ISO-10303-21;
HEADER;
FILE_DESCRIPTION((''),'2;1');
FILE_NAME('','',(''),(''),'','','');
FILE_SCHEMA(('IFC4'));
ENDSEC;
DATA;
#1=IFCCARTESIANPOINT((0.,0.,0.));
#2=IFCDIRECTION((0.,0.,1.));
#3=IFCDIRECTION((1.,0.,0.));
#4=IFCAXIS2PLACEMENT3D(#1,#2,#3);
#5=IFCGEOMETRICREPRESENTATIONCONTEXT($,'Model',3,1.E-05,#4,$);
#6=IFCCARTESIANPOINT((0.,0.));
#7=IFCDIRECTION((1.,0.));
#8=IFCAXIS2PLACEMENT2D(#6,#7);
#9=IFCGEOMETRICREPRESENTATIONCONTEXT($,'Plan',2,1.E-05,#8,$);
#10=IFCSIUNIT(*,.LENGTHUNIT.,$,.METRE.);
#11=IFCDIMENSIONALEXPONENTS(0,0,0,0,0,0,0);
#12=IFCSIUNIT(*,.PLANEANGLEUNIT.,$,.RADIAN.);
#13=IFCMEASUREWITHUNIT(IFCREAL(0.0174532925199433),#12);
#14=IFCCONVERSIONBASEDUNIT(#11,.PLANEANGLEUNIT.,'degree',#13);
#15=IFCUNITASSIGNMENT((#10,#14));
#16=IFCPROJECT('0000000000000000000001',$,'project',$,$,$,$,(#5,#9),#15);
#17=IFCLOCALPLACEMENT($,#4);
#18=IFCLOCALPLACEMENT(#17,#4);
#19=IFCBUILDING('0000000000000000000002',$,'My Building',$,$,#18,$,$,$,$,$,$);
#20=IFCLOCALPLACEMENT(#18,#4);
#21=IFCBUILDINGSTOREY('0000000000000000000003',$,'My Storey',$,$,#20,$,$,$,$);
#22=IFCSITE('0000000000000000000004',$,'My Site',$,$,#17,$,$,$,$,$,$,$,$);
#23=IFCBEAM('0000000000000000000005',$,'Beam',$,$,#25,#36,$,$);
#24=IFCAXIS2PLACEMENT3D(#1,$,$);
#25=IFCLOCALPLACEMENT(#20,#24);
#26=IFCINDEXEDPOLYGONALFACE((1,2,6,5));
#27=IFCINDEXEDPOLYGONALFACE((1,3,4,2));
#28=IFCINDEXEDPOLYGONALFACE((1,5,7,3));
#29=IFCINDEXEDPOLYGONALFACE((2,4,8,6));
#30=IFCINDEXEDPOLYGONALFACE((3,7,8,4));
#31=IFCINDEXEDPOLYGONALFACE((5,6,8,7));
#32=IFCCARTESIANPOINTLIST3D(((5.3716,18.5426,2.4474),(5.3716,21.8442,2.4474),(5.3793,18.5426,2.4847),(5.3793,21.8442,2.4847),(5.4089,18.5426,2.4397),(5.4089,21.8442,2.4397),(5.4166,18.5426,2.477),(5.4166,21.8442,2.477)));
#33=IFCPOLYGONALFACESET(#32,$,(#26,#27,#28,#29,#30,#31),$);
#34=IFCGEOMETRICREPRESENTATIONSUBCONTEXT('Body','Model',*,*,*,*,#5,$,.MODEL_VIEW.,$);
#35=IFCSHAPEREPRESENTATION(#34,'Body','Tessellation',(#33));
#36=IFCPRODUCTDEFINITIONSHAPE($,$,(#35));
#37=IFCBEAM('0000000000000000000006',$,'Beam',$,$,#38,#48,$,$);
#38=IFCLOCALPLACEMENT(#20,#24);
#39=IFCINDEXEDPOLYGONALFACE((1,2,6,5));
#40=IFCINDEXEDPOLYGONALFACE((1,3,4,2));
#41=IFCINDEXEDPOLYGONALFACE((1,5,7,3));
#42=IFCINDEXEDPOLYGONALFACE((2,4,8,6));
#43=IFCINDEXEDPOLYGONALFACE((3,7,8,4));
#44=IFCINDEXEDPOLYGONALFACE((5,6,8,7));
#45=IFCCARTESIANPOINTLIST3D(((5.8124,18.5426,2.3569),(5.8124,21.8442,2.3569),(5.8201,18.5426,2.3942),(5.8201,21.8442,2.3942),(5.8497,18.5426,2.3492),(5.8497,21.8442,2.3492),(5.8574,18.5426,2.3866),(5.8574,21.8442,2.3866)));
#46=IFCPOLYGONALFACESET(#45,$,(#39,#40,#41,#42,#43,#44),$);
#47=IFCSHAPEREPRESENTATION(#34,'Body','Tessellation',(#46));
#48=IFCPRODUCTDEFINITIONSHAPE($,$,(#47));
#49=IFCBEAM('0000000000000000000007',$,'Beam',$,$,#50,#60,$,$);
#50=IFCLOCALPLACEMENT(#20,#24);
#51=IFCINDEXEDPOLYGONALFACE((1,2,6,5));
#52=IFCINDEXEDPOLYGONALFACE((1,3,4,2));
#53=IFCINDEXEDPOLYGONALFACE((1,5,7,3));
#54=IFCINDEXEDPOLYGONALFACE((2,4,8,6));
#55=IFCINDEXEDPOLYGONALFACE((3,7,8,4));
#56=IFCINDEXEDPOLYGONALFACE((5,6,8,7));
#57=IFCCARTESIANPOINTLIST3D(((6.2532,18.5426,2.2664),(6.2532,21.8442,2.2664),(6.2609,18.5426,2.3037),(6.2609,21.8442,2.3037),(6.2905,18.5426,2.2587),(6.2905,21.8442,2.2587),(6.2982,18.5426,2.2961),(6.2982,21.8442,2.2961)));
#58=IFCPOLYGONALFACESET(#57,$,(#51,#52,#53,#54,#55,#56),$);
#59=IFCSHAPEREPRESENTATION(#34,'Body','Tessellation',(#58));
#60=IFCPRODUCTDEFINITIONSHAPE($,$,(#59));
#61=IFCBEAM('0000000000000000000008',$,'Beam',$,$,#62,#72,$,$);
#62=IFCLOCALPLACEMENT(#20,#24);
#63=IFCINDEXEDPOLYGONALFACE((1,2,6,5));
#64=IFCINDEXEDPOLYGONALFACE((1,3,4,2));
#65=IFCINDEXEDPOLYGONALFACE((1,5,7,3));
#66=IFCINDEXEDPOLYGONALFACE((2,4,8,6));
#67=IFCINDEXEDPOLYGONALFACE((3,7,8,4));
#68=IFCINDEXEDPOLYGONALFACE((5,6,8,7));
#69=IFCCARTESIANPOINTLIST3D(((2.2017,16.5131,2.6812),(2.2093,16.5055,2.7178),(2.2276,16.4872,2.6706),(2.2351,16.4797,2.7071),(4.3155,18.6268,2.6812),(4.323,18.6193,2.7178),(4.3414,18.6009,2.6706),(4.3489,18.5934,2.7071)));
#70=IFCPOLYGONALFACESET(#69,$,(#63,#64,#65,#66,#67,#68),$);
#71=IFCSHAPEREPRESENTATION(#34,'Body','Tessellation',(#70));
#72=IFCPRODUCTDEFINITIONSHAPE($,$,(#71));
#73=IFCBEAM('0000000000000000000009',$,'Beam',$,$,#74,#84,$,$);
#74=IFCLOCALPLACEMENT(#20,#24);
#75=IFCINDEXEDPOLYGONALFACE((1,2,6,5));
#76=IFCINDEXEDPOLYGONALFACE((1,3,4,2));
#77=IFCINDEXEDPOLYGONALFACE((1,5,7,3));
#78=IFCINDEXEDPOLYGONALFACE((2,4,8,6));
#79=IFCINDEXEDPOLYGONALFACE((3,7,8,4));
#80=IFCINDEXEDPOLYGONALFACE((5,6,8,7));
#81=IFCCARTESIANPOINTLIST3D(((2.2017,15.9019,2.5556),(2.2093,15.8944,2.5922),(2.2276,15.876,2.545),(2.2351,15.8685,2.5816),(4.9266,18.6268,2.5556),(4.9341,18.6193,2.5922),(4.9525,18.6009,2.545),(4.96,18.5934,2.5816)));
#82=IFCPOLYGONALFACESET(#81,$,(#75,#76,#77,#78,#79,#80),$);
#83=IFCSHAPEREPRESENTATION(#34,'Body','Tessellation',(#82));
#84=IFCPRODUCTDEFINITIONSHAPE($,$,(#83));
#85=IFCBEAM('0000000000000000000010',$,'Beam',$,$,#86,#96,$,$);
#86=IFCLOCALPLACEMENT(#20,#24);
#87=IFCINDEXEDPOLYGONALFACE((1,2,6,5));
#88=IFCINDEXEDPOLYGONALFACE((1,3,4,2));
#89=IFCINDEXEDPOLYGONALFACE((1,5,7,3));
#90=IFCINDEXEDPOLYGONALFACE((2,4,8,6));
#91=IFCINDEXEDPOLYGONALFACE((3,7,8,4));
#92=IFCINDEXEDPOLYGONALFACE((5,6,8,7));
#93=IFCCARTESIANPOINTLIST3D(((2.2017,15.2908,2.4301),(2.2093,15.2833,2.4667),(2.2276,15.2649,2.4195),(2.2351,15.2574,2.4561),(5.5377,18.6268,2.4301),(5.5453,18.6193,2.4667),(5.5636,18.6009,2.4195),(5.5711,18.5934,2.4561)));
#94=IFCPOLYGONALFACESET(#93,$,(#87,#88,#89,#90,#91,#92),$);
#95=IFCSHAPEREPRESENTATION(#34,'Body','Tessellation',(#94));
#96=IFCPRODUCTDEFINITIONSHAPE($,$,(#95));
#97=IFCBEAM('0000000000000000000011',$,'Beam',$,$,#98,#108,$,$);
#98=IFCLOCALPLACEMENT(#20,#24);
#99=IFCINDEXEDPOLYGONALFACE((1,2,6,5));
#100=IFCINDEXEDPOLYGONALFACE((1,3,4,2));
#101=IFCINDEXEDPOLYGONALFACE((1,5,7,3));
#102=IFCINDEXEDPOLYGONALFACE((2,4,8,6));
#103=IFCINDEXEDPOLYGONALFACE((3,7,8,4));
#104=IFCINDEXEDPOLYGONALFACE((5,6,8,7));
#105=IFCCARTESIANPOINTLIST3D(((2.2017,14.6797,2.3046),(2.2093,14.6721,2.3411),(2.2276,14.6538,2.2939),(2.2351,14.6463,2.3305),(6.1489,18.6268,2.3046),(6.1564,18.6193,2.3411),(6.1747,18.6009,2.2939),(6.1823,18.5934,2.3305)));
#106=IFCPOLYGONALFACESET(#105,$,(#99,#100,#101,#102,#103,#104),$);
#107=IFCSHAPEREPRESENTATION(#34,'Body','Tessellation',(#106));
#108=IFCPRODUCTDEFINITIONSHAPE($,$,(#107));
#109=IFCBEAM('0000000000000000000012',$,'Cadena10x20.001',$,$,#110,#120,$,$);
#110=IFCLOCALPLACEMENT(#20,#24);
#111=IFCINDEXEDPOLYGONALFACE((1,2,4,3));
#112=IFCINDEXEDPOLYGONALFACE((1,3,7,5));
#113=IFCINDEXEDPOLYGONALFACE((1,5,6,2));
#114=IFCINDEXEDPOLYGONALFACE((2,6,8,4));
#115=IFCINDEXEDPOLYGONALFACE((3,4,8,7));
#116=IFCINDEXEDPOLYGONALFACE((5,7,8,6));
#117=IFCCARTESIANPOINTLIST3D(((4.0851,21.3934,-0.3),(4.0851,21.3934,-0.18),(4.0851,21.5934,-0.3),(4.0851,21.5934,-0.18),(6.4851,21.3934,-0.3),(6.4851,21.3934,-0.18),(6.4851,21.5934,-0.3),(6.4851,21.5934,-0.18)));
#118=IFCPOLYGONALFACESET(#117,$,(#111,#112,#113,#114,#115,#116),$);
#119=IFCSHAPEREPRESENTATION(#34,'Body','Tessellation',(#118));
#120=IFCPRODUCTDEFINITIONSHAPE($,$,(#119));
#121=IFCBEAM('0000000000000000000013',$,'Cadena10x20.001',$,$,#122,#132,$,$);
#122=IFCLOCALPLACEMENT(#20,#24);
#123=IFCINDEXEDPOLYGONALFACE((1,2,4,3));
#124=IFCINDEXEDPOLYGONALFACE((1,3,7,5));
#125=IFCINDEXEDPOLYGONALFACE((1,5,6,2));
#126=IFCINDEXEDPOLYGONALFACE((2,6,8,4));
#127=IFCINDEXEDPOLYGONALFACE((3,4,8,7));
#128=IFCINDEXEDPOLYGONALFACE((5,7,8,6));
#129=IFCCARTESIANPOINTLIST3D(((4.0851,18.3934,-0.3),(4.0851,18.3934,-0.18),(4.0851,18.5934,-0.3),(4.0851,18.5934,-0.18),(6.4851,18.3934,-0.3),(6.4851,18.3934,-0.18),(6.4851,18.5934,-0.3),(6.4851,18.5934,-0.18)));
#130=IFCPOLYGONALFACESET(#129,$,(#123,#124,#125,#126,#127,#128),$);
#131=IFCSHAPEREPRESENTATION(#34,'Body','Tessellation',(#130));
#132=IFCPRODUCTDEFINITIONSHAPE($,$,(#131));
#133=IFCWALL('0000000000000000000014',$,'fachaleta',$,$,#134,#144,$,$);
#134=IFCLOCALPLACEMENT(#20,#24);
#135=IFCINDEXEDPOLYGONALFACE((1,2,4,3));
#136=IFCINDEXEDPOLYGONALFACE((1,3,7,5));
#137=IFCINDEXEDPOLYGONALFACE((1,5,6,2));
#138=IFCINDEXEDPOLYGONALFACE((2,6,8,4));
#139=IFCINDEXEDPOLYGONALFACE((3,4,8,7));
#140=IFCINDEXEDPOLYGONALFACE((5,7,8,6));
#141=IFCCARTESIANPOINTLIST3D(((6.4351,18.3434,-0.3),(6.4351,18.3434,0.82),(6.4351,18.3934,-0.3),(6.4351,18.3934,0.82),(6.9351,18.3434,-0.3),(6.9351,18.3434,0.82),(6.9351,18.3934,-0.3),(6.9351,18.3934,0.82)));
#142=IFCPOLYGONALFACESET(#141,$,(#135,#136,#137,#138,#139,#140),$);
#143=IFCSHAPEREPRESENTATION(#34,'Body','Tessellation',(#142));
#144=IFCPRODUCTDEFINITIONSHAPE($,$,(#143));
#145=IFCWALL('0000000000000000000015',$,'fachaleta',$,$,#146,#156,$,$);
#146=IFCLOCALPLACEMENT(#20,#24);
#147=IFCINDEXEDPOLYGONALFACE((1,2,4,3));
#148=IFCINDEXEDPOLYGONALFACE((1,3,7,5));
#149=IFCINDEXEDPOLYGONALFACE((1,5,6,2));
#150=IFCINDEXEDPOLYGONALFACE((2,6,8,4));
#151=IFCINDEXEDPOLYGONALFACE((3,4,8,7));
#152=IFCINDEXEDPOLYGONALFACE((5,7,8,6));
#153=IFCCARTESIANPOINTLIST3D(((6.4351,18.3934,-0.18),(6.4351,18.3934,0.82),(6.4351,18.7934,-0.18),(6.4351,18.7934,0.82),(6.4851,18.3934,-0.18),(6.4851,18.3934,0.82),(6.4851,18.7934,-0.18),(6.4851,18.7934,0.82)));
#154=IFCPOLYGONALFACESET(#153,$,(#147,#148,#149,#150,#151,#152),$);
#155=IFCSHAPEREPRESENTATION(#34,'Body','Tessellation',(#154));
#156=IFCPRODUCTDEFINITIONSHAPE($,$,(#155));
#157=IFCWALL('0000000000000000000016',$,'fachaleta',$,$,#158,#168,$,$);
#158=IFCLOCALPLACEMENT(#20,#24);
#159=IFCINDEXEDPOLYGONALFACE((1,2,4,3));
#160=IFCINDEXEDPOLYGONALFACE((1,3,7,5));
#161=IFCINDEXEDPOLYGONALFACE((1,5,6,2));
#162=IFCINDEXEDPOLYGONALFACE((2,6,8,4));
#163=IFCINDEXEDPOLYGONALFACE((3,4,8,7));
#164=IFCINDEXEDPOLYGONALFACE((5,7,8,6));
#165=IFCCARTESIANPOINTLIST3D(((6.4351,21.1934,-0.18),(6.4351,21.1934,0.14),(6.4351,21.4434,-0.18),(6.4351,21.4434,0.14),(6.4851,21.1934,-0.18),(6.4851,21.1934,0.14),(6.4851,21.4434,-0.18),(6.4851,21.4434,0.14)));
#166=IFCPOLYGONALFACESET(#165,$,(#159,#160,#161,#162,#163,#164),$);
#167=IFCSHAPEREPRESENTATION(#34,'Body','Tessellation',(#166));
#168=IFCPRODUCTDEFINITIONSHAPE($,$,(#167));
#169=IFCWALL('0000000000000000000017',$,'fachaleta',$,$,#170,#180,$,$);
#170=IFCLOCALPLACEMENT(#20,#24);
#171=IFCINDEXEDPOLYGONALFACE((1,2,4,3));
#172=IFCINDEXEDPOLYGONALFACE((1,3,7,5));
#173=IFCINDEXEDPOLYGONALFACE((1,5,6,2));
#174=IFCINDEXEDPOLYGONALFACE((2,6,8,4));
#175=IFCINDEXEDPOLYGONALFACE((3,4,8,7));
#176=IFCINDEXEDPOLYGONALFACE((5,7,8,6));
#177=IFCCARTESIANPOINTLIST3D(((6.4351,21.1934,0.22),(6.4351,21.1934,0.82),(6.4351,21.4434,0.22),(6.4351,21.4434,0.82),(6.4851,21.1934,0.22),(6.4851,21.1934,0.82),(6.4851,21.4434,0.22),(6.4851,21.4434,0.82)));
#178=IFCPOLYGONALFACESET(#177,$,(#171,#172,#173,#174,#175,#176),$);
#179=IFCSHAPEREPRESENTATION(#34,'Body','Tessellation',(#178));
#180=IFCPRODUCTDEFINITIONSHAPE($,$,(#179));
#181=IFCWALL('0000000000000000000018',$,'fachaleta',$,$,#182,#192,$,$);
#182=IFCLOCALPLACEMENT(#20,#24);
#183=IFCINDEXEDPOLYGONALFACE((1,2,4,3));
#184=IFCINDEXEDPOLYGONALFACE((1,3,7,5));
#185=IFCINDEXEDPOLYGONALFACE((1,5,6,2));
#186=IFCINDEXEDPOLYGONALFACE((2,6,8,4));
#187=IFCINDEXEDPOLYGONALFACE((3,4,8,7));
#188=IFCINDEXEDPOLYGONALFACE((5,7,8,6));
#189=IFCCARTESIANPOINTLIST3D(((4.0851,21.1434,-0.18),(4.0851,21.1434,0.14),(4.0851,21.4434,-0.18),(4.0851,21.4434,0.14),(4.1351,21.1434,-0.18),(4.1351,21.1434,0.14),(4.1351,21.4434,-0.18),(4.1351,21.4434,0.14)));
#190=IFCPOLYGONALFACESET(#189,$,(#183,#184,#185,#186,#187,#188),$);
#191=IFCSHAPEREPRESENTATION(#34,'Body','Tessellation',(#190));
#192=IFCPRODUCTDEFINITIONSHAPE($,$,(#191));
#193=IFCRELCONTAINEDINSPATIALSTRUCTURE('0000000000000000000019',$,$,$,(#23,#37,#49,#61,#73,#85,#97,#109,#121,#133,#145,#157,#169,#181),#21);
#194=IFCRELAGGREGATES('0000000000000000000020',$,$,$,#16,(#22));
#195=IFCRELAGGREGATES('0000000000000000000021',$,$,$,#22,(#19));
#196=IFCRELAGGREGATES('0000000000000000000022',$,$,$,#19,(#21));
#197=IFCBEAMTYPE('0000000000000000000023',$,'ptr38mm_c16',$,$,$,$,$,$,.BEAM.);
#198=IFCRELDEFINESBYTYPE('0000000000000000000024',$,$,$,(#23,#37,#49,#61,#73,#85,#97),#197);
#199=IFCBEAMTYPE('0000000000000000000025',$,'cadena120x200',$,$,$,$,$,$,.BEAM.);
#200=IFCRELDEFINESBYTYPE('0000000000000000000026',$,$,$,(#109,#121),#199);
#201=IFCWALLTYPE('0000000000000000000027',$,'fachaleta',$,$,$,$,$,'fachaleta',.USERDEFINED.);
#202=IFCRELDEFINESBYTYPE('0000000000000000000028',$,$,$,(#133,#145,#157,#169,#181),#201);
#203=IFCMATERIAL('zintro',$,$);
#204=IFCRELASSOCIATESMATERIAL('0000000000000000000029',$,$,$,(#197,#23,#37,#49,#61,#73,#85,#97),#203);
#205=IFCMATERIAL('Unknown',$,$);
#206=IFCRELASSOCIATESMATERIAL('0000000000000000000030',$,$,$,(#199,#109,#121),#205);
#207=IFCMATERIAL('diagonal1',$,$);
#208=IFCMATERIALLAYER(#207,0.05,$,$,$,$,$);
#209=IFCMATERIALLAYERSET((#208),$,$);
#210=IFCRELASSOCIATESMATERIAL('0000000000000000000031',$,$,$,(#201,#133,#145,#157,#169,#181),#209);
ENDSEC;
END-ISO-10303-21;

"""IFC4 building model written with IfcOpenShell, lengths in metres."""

from ifc_helpers import new_model, entity, si_unit, converted_unit, frame, origin_with_axes, origin_2d_with_axis, place, context, subcontext, project, spatial, indexed_curve, rectangle, outline, extrude, material, layer, layer_set, layer_usage, material_profile, profile_set, profile_usage, type_object, element, save


model = new_model("IFC4")

# Units and contexts
model_context = context("Model", 3, precision=1e-05, world=origin_with_axes())
plan_context = context("Plan", 2, precision=1e-05, world=origin_2d_with_axis())
body_context = subcontext(model_context, "Body", "Model", "MODEL_VIEW")
ifc_project = project(units=[si_unit("LENGTHUNIT", "METRE"), converted_unit("PLANEANGLEUNIT", "degree", entity("IfcReal", 0.0174532925199433), si_unit("PLANEANGLEUNIT", "RADIAN"), dimensions=[0, 0, 0, 0, 0, 0, 0])], contexts=[model_context, plan_context])

# Site, building, storey
site_placement = place(None, origin_with_axes())
site = spatial("IfcSite", under=ifc_project, at=site_placement, Name="My Site")
building_placement = place(site_placement, origin_with_axes())
building = spatial("IfcBuilding", under=site, at=building_placement, Name="My Building")
storey_placement = place(building_placement, origin_with_axes())
storey = spatial("IfcBuildingStorey", under=building, at=storey_placement, Name="My Storey")

# Beams
ifc_material_1 = material(Name="zintro")
ifc_material_profile_1 = material_profile(ifc_material_1, rectangle(XDim=0.0381, YDim=0.0381))
ifc_profile_set_1 = profile_set([ifc_material_profile_1])
beam_type_1 = type_object("IfcBeamType", Name="ptr38mm_c16", PredefinedType="BEAM", material=ifc_profile_set_1)
ifc_profile_usage_1 = profile_usage(ifc_profile_set_1)
beam_1_placement = place(storey_placement, frame((5.3941, 21.8442, 2.4622), z_axis=(0.0, -1.0, 0.0), x_axis=(0.979575, 0.0, -0.201078)))
element("IfcBeam", 1, at=beam_1_placement, inside=storey, type_object=beam_type_1, material=ifc_profile_usage_1, Name="Beam", context=body_context, shape_type="SweptSolid", body=[
    extrude(rectangle(XDim=0.0381, YDim=0.0381), origin_with_axes(), (0.0, 0.0, 1.0), 3.3016),
])
ifc_profile_usage_2 = profile_usage(ifc_profile_set_1)
beam_2_placement = place(storey_placement, frame((5.8349, 21.8442, 2.3717), z_axis=(0.0, -1.0, 0.0), x_axis=(0.979575, 0.0, -0.201078)))
element("IfcBeam", 2, at=beam_2_placement, inside=storey, type_object=beam_type_1, material=ifc_profile_usage_2, Name="Beam", context=body_context, shape_type="SweptSolid", body=[
    extrude(rectangle(XDim=0.0381, YDim=0.0381), origin_with_axes(), (0.0, 0.0, 1.0), 3.3016),
])
ifc_profile_usage_3 = profile_usage(ifc_profile_set_1)
beam_3_placement = place(storey_placement, frame((6.2757, 21.8442, 2.2812), z_axis=(0.0, -1.0, 0.0), x_axis=(0.979575, 0.0, -0.201078)))
element("IfcBeam", 3, at=beam_3_placement, inside=storey, type_object=beam_type_1, material=ifc_profile_usage_3, Name="Beam", context=body_context, shape_type="SweptSolid", body=[
    extrude(rectangle(XDim=0.0381, YDim=0.0381), origin_with_axes(), (0.0, 0.0, 1.0), 3.3016),
])
ifc_profile_usage_4 = profile_usage(ifc_profile_set_1)
beam_4_placement = place(storey_placement, frame((4.3322, 18.6101, 2.6942), z_axis=(-0.707107, -0.707107, 0.0), x_axis=(0.67903, -0.67903, -0.278991)))
element("IfcBeam", 4, at=beam_4_placement, inside=storey, type_object=beam_type_1, material=ifc_profile_usage_4, Name="Beam", context=body_context, shape_type="SweptSolid", body=[
    extrude(rectangle(XDim=0.0381, YDim=0.0381), origin_with_axes(), (0.0, 0.0, 1.0), 2.9893),
])
ifc_profile_usage_5 = profile_usage(ifc_profile_set_1)
beam_5_placement = place(storey_placement, frame((4.9433, 18.6101, 2.5686), z_axis=(-0.707107, -0.707107, 0.0), x_axis=(0.67903, -0.67903, -0.278991)))
element("IfcBeam", 5, at=beam_5_placement, inside=storey, type_object=beam_type_1, material=ifc_profile_usage_5, Name="Beam", context=body_context, shape_type="SweptSolid", body=[
    extrude(rectangle(XDim=0.0381, YDim=0.0381), origin_with_axes(), (0.0, 0.0, 1.0), 3.8535),
])
ifc_profile_usage_6 = profile_usage(ifc_profile_set_1)
beam_6_placement = place(storey_placement, frame((5.5544, 18.6101, 2.4431), z_axis=(-0.707107, -0.707107, 0.0), x_axis=(0.67903, -0.67903, -0.278991)))
element("IfcBeam", 6, at=beam_6_placement, inside=storey, type_object=beam_type_1, material=ifc_profile_usage_6, Name="Beam", context=body_context, shape_type="SweptSolid", body=[
    extrude(rectangle(XDim=0.0381, YDim=0.0381), origin_with_axes(), (0.0, 0.0, 1.0), 4.7178),
])
ifc_profile_usage_7 = profile_usage(ifc_profile_set_1)
beam_7_placement = place(storey_placement, frame((6.1656, 18.6101, 2.3175), z_axis=(-0.707107, -0.707107, 0.0), x_axis=(0.67903, -0.67903, -0.278991)))
element("IfcBeam", 7, at=beam_7_placement, inside=storey, type_object=beam_type_1, material=ifc_profile_usage_7, Name="Beam", context=body_context, shape_type="SweptSolid", body=[
    extrude(rectangle(XDim=0.0381, YDim=0.0381), origin_with_axes(), (0.0, 0.0, 1.0), 5.5821),
])
ifc_material_2 = material(Name="Unknown")
ifc_material_profile_2 = material_profile(ifc_material_2, rectangle(XDim=0.2, YDim=0.12))
ifc_profile_set_2 = profile_set([ifc_material_profile_2], Name="concrete")
ifc_profile_usage_8 = profile_usage(ifc_profile_set_2, cardinal=5)
beam_type_2 = type_object("IfcBeamType", Name="cadena120x200", PredefinedType="BEAM", material=ifc_profile_set_2)
beam_8_placement = place(storey_placement, frame((6.4851, 21.4934, -0.24), z_axis=(-1.0, 0.0, 0.0), x_axis=(0.0, -1.0, 0.0)))
element("IfcBeam", 8, at=beam_8_placement, inside=storey, type_object=beam_type_2, material=ifc_profile_usage_8, Name="Cadena10x20.001", context=body_context, shape_type="SweptSolid", body=[
    extrude(rectangle(XDim=0.2, YDim=0.12), origin_with_axes(), (0.0, 0.0, 1.0), 2.4),
])
ifc_profile_usage_9 = profile_usage(ifc_profile_set_2, cardinal=5)
beam_9_placement = place(storey_placement, frame((6.4851, 18.4934, -0.24), z_axis=(-1.0, 0.0, 0.0), x_axis=(0.0, -1.0, 0.0)))
element("IfcBeam", 9, at=beam_9_placement, inside=storey, type_object=beam_type_2, material=ifc_profile_usage_9, Name="Cadena10x20.001", context=body_context, shape_type="SweptSolid", body=[
    extrude(rectangle(XDim=0.2, YDim=0.12), origin_with_axes(), (0.0, 0.0, 1.0), 2.4),
])

# Walls
ifc_material_3 = material(Name="diagonal1")
ifc_layer_1 = layer(ifc_material_3, 0.05)
ifc_layer_set_1 = layer_set([ifc_layer_1])
ifc_layer_usage_1 = layer_usage(ifc_layer_set_1, "AXIS2", "POSITIVE", 0.0)
wall_type_1 = type_object("IfcWallType", Name="fachaleta", ElementType="fachaleta", PredefinedType="USERDEFINED", material=ifc_layer_set_1)
wall_1_placement = place(storey_placement, frame((6.4351, 18.3434, -0.3), z_axis=(0.0, 0.0, 1.0), x_axis=(1.0, 0.0, 0.0)))
element("IfcWall", 10, at=wall_1_placement, inside=storey, type_object=wall_type_1, material=ifc_layer_usage_1, Name="fachaleta", context=body_context, shape_type="SweptSolid", body=[
    extrude(outline(indexed_curve([(0.0, 0.0), (0.0, 0.05), (0.5, 0.05), (0.5, 0.0), (0.0, 0.0)], self_intersect=False)), origin_with_axes(), (0.0, 0.0, 1.0), 1.12),
])
ifc_layer_usage_2 = layer_usage(ifc_layer_set_1, "AXIS2", "POSITIVE", 0.0)
wall_2_placement = place(storey_placement, frame((6.4851, 18.3934, -0.18), z_axis=(0.0, 0.0, 1.0), x_axis=(0.000001, 1.0, 0.0)))
element("IfcWall", 11, at=wall_2_placement, inside=storey, type_object=wall_type_1, material=ifc_layer_usage_2, Name="fachaleta", context=body_context, shape_type="SweptSolid", body=[
    extrude(outline(indexed_curve([(0.0, 0.0), (0.0, 0.05), (0.4, 0.05), (0.4, 0.0), (0.0, 0.0)], self_intersect=False)), origin_with_axes(), (0.0, 0.0, 1.0), 1.0),
])
ifc_layer_usage_3 = layer_usage(ifc_layer_set_1, "AXIS2", "POSITIVE", 0.0)
wall_3_placement = place(storey_placement, frame((6.4851, 21.1934, -0.18), z_axis=(0.0, 0.0, 1.0), x_axis=(0.000001, 1.0, 0.0)))
element("IfcWall", 12, at=wall_3_placement, inside=storey, type_object=wall_type_1, material=ifc_layer_usage_3, Name="fachaleta", context=body_context, shape_type="SweptSolid", body=[
    extrude(outline(indexed_curve([(0.0, 0.0), (0.0, 0.05), (0.25, 0.05), (0.25, 0.0), (0.0, 0.0)], self_intersect=False)), origin_with_axes(), (0.0, 0.0, 1.0), 0.32),
])
ifc_layer_usage_4 = layer_usage(ifc_layer_set_1, "AXIS2", "POSITIVE", 0.0)
wall_4_placement = place(storey_placement, frame((6.4851, 21.1934, 0.22), z_axis=(0.0, 0.0, 1.0), x_axis=(0.000001, 1.0, 0.0)))
element("IfcWall", 13, at=wall_4_placement, inside=storey, type_object=wall_type_1, material=ifc_layer_usage_4, Name="fachaleta", context=body_context, shape_type="SweptSolid", body=[
    extrude(outline(indexed_curve([(0.0, 0.0), (0.0, 0.05), (0.25, 0.05), (0.25, 0.0), (0.0, 0.0)], self_intersect=False)), origin_with_axes(), (0.0, 0.0, 1.0), 0.6),
])
ifc_layer_usage_5 = layer_usage(ifc_layer_set_1, "AXIS2", "POSITIVE", 0.0)
wall_5_placement = place(storey_placement, frame((4.1351, 21.1434, -0.18), z_axis=(0.0, 0.0, 1.0), x_axis=(0.000001, 1.0, 0.0)))
element("IfcWall", 14, at=wall_5_placement, inside=storey, type_object=wall_type_1, material=ifc_layer_usage_5, Name="fachaleta", context=body_context, shape_type="SweptSolid", body=[
    extrude(outline(indexed_curve([(0.0, 0.0), (0.0, 0.05), (0.3, 0.05), (0.3, 0.0), (0.0, 0.0)], self_intersect=False)), origin_with_axes(), (0.0, 0.0, 1.0), 0.32),
])

save(model, "model.ifc")
